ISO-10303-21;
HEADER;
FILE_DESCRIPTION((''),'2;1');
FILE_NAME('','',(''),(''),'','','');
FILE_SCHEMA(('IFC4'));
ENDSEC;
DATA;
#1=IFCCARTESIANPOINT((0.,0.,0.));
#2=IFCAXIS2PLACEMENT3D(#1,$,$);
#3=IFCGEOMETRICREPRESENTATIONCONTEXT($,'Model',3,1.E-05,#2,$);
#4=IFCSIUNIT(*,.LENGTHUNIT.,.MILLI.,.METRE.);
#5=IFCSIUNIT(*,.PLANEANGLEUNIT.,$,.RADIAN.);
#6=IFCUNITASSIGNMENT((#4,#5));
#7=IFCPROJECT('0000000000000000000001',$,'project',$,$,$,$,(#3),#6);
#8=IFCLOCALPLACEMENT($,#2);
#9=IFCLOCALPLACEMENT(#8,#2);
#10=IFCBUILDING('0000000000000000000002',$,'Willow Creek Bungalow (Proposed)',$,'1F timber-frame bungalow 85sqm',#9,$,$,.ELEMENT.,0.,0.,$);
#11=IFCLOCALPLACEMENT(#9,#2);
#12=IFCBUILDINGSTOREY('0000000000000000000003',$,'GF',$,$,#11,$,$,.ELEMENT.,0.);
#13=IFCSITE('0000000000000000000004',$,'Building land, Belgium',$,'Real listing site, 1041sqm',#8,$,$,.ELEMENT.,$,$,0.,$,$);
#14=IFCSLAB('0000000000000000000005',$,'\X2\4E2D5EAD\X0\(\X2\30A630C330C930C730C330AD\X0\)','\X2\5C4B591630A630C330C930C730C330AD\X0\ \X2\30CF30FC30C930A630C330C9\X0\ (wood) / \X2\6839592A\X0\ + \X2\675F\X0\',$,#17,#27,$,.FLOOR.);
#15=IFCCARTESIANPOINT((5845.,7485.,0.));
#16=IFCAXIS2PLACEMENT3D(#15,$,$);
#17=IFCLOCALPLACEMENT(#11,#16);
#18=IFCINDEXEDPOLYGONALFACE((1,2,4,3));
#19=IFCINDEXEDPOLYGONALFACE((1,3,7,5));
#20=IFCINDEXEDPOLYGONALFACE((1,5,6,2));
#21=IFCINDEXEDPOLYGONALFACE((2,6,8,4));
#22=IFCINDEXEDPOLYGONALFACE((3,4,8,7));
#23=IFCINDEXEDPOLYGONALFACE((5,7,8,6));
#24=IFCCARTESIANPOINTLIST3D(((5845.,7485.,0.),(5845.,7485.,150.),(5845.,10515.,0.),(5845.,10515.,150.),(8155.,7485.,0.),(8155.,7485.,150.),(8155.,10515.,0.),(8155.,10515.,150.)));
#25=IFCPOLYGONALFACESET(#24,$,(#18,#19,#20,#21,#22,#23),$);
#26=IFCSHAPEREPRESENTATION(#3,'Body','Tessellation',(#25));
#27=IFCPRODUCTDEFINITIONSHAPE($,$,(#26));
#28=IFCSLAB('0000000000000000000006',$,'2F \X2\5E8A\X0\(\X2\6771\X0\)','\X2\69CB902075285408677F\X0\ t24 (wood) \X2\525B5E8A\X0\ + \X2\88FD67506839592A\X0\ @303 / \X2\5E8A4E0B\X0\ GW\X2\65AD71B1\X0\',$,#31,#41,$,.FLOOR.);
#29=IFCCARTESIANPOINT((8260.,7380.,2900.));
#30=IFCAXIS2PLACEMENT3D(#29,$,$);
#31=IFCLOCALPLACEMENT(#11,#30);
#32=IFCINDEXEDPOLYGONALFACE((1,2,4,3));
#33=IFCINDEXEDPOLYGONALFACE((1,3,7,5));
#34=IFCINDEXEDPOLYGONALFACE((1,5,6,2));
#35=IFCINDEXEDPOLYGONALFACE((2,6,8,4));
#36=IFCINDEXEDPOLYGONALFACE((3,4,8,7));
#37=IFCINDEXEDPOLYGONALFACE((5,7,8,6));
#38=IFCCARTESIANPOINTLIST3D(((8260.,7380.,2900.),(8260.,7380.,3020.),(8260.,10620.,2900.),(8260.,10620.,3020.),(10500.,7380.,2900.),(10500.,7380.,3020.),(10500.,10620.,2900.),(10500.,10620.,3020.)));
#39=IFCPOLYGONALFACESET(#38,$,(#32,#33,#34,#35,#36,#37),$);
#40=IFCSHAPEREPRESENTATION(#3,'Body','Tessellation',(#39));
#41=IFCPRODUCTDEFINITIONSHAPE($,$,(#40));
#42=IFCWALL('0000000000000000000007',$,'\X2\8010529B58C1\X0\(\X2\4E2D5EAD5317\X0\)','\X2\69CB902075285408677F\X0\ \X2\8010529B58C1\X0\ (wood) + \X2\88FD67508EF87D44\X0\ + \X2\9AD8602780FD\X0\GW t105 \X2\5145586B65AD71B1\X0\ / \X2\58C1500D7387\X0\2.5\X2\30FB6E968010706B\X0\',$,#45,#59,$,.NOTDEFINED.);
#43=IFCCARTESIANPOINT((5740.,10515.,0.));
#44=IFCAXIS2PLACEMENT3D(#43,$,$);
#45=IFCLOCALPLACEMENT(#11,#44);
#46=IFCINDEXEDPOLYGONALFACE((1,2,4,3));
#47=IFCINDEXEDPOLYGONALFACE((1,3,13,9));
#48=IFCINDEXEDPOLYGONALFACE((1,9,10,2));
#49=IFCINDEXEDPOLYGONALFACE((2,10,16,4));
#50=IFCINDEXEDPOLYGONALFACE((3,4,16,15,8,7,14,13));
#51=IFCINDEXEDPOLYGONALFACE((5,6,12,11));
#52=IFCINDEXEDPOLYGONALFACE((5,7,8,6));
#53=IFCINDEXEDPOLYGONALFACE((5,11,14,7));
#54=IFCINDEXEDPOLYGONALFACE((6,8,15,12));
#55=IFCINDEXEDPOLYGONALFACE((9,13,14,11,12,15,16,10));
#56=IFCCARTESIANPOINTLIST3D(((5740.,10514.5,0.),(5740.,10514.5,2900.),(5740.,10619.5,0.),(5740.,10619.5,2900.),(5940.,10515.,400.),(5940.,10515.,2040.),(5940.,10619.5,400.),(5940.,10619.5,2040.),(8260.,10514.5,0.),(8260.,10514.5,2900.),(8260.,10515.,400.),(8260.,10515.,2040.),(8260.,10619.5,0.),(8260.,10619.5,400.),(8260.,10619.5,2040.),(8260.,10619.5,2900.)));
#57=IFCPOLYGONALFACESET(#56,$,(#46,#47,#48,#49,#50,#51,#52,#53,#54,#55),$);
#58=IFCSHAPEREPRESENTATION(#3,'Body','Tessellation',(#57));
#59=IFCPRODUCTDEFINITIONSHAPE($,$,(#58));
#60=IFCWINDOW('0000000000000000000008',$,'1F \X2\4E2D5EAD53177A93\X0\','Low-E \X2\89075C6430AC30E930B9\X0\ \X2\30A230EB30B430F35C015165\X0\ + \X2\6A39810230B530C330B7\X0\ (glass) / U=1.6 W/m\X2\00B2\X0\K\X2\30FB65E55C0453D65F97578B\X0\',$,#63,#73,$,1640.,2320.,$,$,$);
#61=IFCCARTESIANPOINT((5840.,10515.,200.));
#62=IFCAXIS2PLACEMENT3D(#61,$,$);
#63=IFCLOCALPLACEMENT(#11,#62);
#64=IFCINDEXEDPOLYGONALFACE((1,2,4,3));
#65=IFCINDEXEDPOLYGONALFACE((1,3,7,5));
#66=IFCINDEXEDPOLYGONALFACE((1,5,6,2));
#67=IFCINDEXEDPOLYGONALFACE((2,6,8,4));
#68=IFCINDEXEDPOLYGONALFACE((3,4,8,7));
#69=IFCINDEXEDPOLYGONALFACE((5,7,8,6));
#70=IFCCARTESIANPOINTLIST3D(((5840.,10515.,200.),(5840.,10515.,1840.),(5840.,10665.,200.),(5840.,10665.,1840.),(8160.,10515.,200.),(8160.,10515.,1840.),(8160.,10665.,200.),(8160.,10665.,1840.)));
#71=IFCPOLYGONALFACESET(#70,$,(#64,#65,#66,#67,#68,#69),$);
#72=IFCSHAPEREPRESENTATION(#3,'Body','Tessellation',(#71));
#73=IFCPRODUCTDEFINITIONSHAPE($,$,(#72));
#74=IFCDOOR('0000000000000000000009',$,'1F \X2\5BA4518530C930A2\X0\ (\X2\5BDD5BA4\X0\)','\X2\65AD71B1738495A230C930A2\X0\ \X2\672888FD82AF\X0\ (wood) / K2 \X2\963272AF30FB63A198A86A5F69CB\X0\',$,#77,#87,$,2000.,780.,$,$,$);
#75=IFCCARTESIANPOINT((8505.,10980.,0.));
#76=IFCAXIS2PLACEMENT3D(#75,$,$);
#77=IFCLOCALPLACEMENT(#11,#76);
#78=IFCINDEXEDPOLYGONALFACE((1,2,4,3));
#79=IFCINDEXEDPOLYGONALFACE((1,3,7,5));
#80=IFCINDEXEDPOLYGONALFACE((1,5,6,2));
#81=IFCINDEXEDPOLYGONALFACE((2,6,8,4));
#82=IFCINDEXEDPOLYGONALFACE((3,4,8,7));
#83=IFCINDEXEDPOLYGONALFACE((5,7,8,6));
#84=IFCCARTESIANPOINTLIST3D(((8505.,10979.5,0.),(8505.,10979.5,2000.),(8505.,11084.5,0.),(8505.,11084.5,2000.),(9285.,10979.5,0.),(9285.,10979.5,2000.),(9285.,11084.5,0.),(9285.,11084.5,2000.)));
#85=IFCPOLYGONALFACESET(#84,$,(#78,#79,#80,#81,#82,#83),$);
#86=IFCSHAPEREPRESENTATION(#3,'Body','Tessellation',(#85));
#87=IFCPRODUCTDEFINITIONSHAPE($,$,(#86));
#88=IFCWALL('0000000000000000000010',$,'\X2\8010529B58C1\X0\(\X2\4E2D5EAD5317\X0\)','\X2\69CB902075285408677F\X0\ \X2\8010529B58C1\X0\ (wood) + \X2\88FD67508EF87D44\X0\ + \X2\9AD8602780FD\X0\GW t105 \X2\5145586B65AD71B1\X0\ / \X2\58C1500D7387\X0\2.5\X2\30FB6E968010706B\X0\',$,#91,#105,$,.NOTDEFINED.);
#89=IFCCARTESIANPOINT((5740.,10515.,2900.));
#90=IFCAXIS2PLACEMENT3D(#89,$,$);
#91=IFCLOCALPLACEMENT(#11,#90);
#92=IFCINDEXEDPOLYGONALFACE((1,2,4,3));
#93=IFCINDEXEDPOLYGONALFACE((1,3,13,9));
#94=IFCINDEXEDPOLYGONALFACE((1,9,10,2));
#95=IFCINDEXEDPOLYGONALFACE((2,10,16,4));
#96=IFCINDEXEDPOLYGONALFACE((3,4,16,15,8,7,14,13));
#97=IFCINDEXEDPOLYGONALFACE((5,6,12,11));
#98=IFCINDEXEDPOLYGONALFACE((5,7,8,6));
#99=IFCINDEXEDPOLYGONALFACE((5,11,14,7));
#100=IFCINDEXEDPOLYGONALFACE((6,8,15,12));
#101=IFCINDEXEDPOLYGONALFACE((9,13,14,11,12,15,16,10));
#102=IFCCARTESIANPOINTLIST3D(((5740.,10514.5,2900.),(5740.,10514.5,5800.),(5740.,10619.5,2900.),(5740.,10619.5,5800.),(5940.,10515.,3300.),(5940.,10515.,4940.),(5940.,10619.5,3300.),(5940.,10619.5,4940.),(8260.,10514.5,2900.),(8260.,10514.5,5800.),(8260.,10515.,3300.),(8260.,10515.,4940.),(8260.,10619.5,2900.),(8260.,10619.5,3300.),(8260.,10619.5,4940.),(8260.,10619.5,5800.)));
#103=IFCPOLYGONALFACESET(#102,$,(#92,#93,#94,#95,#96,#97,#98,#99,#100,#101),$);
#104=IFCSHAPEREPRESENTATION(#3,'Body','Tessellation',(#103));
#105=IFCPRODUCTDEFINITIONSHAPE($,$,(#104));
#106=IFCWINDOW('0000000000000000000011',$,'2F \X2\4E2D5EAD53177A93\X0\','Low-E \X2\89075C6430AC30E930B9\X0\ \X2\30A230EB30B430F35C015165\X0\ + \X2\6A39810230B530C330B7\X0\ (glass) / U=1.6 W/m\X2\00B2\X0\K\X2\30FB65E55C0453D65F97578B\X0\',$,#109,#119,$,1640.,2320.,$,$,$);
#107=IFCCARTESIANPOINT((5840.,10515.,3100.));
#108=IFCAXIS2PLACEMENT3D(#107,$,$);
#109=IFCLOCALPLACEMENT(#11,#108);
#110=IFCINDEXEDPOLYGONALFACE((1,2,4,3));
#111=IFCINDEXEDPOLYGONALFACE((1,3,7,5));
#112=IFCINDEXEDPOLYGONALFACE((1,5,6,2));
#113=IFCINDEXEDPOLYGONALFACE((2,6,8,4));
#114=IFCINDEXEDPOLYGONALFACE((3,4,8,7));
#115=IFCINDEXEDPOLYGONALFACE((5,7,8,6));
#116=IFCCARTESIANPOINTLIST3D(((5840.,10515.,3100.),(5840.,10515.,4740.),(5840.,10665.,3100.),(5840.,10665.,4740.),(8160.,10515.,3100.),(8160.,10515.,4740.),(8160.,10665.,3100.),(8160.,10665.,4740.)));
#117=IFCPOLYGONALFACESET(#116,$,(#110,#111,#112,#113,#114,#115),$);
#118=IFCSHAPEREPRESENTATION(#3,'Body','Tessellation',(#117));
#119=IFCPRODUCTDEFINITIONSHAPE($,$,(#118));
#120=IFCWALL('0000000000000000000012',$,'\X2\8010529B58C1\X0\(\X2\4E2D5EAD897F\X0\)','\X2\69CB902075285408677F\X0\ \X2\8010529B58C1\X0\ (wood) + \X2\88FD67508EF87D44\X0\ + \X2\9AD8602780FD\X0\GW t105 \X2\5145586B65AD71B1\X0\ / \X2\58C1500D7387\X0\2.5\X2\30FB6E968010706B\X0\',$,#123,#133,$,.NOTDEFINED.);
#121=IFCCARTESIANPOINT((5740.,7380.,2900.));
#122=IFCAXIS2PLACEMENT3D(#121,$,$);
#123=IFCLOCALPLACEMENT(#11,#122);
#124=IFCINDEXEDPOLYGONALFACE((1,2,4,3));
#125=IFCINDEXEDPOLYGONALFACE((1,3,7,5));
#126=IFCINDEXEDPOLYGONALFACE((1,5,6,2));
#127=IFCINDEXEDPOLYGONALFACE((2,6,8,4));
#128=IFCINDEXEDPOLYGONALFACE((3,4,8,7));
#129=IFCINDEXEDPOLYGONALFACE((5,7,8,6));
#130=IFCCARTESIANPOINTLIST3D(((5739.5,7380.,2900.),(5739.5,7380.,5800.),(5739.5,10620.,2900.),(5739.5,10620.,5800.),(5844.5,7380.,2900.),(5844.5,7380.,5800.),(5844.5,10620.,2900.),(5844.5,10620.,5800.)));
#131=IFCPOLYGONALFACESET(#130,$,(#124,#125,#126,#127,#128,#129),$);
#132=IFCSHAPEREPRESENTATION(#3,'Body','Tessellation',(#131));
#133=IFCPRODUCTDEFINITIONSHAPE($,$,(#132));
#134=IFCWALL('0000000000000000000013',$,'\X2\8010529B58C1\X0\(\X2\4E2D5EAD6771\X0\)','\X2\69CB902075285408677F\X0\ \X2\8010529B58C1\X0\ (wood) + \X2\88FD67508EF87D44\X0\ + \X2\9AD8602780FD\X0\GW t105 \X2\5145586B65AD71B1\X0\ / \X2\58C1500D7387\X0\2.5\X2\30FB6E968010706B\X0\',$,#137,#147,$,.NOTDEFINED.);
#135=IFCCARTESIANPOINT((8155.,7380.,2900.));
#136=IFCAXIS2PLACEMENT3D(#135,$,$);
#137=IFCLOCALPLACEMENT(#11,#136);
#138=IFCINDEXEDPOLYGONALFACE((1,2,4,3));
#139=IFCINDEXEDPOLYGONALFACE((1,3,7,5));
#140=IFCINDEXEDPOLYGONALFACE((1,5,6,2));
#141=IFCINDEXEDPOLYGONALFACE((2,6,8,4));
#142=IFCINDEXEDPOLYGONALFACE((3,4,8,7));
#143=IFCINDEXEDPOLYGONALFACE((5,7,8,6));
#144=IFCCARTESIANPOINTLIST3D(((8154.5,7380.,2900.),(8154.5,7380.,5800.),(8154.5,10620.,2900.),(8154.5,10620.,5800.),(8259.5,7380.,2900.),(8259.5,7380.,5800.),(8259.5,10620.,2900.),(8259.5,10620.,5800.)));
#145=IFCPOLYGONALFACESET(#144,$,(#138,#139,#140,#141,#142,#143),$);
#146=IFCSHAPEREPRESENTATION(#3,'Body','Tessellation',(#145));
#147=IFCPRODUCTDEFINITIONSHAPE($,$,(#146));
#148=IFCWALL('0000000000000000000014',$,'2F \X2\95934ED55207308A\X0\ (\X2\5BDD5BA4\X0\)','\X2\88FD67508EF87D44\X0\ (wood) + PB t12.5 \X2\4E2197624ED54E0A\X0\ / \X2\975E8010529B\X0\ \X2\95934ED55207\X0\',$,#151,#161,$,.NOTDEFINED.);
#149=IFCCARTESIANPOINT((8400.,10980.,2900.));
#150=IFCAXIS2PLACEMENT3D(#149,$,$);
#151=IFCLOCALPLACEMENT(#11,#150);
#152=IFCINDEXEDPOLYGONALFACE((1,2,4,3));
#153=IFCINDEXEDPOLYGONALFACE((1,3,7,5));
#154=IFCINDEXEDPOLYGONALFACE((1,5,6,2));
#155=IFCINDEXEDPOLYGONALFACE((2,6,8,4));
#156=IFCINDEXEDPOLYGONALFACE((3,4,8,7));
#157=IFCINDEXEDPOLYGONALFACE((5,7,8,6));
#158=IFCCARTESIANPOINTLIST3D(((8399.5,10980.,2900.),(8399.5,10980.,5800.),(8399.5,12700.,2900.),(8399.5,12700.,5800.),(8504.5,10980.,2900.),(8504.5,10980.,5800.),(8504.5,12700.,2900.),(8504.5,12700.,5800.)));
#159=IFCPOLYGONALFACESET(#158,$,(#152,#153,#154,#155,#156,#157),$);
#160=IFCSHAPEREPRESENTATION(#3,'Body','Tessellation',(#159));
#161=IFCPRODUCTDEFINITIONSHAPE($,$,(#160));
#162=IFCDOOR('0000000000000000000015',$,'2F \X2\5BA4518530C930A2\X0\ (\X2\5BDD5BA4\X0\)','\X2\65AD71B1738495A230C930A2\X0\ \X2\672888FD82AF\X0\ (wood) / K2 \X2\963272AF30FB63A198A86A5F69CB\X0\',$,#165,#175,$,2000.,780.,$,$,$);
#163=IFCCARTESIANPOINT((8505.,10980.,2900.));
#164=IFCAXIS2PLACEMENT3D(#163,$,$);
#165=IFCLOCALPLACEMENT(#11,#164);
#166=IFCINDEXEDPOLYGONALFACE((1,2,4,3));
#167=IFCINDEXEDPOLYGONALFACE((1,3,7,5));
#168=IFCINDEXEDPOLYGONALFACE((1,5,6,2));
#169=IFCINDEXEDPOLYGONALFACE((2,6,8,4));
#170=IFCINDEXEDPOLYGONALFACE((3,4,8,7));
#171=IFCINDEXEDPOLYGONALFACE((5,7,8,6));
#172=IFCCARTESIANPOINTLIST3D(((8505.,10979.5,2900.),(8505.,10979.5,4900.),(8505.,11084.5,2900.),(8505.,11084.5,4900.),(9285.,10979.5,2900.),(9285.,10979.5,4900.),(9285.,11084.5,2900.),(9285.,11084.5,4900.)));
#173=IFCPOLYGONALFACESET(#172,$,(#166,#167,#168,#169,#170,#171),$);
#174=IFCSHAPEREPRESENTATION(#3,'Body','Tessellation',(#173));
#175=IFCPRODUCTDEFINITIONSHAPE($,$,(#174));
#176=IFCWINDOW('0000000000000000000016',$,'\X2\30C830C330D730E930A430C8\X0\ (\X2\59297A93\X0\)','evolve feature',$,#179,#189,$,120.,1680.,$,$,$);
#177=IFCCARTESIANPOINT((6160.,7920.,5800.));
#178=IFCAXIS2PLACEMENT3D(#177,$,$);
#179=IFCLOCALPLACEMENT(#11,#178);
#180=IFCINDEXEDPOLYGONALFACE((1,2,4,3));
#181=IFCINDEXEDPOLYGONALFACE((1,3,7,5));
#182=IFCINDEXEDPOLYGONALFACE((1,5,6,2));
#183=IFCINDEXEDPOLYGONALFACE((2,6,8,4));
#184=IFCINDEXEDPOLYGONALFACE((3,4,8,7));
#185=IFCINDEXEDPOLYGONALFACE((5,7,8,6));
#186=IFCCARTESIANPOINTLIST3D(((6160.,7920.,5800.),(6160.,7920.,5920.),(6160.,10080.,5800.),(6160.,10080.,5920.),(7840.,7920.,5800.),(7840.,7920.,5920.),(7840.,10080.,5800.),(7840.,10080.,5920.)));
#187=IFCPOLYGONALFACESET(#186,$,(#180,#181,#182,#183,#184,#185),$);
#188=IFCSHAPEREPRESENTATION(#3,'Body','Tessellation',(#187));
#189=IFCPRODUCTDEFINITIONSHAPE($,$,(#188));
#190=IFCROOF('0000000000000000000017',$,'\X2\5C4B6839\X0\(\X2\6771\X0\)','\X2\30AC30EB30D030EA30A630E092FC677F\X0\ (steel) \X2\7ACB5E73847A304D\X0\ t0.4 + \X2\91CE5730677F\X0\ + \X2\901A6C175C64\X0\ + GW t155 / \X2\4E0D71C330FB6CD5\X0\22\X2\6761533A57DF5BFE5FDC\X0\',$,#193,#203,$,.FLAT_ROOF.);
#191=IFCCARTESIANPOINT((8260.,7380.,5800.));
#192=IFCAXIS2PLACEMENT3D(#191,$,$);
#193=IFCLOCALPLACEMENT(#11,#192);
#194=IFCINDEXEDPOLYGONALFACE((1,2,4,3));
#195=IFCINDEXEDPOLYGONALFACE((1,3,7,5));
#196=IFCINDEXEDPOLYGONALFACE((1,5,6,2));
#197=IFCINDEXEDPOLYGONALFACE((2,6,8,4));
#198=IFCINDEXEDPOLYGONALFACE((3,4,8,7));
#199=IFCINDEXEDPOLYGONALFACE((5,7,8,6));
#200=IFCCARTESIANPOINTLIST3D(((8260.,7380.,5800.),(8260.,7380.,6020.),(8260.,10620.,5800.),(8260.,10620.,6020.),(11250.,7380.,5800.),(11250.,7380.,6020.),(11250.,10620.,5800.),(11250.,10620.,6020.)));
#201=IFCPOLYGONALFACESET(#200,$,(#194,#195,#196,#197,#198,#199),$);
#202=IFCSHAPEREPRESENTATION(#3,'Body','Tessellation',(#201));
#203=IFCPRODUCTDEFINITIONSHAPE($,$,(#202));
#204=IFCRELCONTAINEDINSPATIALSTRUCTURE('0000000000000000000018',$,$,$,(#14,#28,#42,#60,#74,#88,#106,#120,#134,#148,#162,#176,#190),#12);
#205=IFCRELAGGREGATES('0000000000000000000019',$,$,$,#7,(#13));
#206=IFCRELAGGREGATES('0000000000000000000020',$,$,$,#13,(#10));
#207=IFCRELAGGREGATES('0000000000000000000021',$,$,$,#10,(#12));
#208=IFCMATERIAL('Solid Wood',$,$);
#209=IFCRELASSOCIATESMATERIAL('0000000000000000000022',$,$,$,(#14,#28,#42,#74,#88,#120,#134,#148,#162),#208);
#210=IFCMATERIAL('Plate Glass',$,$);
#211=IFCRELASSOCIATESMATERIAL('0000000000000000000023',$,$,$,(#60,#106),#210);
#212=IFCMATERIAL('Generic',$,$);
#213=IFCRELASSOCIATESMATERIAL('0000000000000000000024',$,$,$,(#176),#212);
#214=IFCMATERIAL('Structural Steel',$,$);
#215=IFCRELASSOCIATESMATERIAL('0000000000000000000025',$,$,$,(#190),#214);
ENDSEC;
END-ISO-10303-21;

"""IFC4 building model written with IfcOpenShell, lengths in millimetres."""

from ifc_helpers import new_model, si_unit, frame, frame_2d, origin, place, context, project, spatial, rectangle, extrude, material, element, fill, save


model = new_model("IFC4")

# Units and contexts
model_context = context("Model", 3, precision=1e-05, world=origin())
ifc_project = project(units=[si_unit("LENGTHUNIT", "METRE", prefix="MILLI"), si_unit("PLANEANGLEUNIT", "RADIAN")], contexts=[model_context])

# Site, building, storey
site_placement = place(None, origin())
site = spatial("IfcSite", under=ifc_project, at=site_placement, Name="Building land, Belgium", ObjectType="Real listing site, 1041sqm", CompositionType="ELEMENT", RefElevation=0.0)
building_placement = place(site_placement, origin())
building = spatial("IfcBuilding", under=site, at=building_placement, Name="Willow Creek Bungalow (Proposed)", ObjectType="1F timber-frame bungalow 85sqm", CompositionType="ELEMENT", ElevationOfRefHeight=0.0, ElevationOfTerrain=0.0)
storey_placement = place(building_placement, origin())
storey = spatial("IfcBuildingStorey", under=building, at=storey_placement, Name="GF", CompositionType="ELEMENT", Elevation=0.0)

# Slabs
ifc_material_1 = material(Name="Solid Wood")
slab_1_placement = place(storey_placement, frame((5845.0, 7485.0, 0.0)))
element("IfcSlab", 1, at=slab_1_placement, inside=storey, material=ifc_material_1, Name="中庭(ウッドデッキ)", Description="屋外ウッドデッキ ハードウッド (wood) / 根太 + 束", PredefinedType="FLOOR", context=model_context, shape_type="SweptSolid", body=[
    extrude(rectangle(XDim=2310.0, YDim=3030.0, at=frame_2d((1155.0, 1515.0))), frame((5845.0, 7485.0, 0.0)), (0.0, 0.0, 1.0), 150.0),
])
slab_2_placement = place(storey_placement, frame((8260.0, 7380.0, 2900.0)))
element("IfcSlab", 2, at=slab_2_placement, inside=storey, material=ifc_material_1, Name="2F 床(東)", Description="構造用合板 t24 (wood) 剛床 + 製材根太 @303 / 床下 GW断熱", PredefinedType="FLOOR", context=model_context, shape_type="SweptSolid", body=[
    extrude(rectangle(XDim=2240.0, YDim=3240.0, at=frame_2d((1120.0, 1620.0))), frame((8260.0, 7380.0, 2900.0)), (0.0, 0.0, 1.0), 120.0),
])

# Wall, opening, window
wall_1_placement = place(storey_placement, frame((5740.0, 10515.0, 0.0)))
wall_1 = element("IfcWall", 3, at=wall_1_placement, inside=storey, material=ifc_material_1, Name="耐力壁(中庭北)", Description="構造用合板 耐力壁 (wood) + 製材軸組 + 高性能GW t105 充填断熱 / 壁倍率2.5・準耐火", PredefinedType="NOTDEFINED", context=model_context, shape_type="SweptSolid", body=[
    extrude(rectangle(XDim=2520.0, YDim=105.0, at=frame_2d((1260.0, 52.0))), frame((5740.0, 10515.0, 0.0)), (0.0, 0.0, 1.0), 2900.0),
])
opening_1_placement = place(storey_placement, frame((5840.0, 10515.0, 200.0)))
opening_1 = element("IfcOpeningElement", 4, at=opening_1_placement, cuts=wall_1, PredefinedType="NOTDEFINED", context=model_context, shape_type="SweptSolid", body=[
    extrude(rectangle(XDim=2320.0, YDim=150.0, at=frame_2d((1160.0, 75.0))), frame((5840.0, 10515.0, 200.0)), (0.0, 0.0, 1.0), 1640.0),
])
ifc_material_2 = material(Name="Plate Glass")
window_1_placement = place(storey_placement, frame((5840.0, 10515.0, 200.0)))
window_1 = element("IfcWindow", 5, at=window_1_placement, inside=storey, material=ifc_material_2, Name="1F 中庭北窓", Description="Low-E 複層ガラス アルゴン封入 + 樹脂サッシ (glass) / U=1.6 W/m²K・日射取得型", OverallHeight=1640.0, OverallWidth=2320.0, context=model_context, shape_type="SweptSolid", body=[
    extrude(rectangle(XDim=2320.0, YDim=150.0, at=frame_2d((1160.0, 75.0))), frame((5840.0, 10515.0, 200.0)), (0.0, 0.0, 1.0), 1640.0),
])
fill(opening_1, window_1)

# Door
door_1_placement = place(storey_placement, frame((8505.0, 10980.0, 0.0)))
element("IfcDoor", 6, at=door_1_placement, inside=storey, material=ifc_material_1, Name="1F 室内ドア (寝室)", Description="断熱玄関ドア 木製芯 (wood) / K2 防犯・採風機構", OverallHeight=2000.0, OverallWidth=780.0, context=model_context, shape_type="SweptSolid", body=[
    extrude(rectangle(XDim=780.0, YDim=105.0, at=frame_2d((390.0, 52.0))), frame((8505.0, 10980.0, 0.0)), (0.0, 0.0, 1.0), 2000.0),
])

# Wall, opening, window
wall_2_placement = place(storey_placement, frame((5740.0, 10515.0, 2900.0)))
wall_2 = element("IfcWall", 7, at=wall_2_placement, inside=storey, material=ifc_material_1, Name="耐力壁(中庭北)", Description="構造用合板 耐力壁 (wood) + 製材軸組 + 高性能GW t105 充填断熱 / 壁倍率2.5・準耐火", PredefinedType="NOTDEFINED", context=model_context, shape_type="SweptSolid", body=[
    extrude(rectangle(XDim=2520.0, YDim=105.0, at=frame_2d((1260.0, 52.0))), frame((5740.0, 10515.0, 2900.0)), (0.0, 0.0, 1.0), 2900.0),
])
opening_2_placement = place(storey_placement, frame((5840.0, 10515.0, 3100.0)))
opening_2 = element("IfcOpeningElement", 8, at=opening_2_placement, cuts=wall_2, PredefinedType="NOTDEFINED", context=model_context, shape_type="SweptSolid", body=[
    extrude(rectangle(XDim=2320.0, YDim=150.0, at=frame_2d((1160.0, 75.0))), frame((5840.0, 10515.0, 3100.0)), (0.0, 0.0, 1.0), 1640.0),
])
window_2_placement = place(storey_placement, frame((5840.0, 10515.0, 3100.0)))
window_2 = element("IfcWindow", 9, at=window_2_placement, inside=storey, material=ifc_material_2, Name="2F 中庭北窓", Description="Low-E 複層ガラス アルゴン封入 + 樹脂サッシ (glass) / U=1.6 W/m²K・日射取得型", OverallHeight=1640.0, OverallWidth=2320.0, context=model_context, shape_type="SweptSolid", body=[
    extrude(rectangle(XDim=2320.0, YDim=150.0, at=frame_2d((1160.0, 75.0))), frame((5840.0, 10515.0, 3100.0)), (0.0, 0.0, 1.0), 1640.0),
])
fill(opening_2, window_2)

# Walls
wall_3_placement = place(storey_placement, frame((5740.0, 7380.0, 2900.0)))
element("IfcWall", 10, at=wall_3_placement, inside=storey, material=ifc_material_1, Name="耐力壁(中庭西)", Description="構造用合板 耐力壁 (wood) + 製材軸組 + 高性能GW t105 充填断熱 / 壁倍率2.5・準耐火", PredefinedType="NOTDEFINED", context=model_context, shape_type="SweptSolid", body=[
    extrude(rectangle(XDim=105.0, YDim=3240.0, at=frame_2d((52.0, 1620.0))), frame((5740.0, 7380.0, 2900.0)), (0.0, 0.0, 1.0), 2900.0),
])
wall_4_placement = place(storey_placement, frame((8155.0, 7380.0, 2900.0)))
element("IfcWall", 11, at=wall_4_placement, inside=storey, material=ifc_material_1, Name="耐力壁(中庭東)", Description="構造用合板 耐力壁 (wood) + 製材軸組 + 高性能GW t105 充填断熱 / 壁倍率2.5・準耐火", PredefinedType="NOTDEFINED", context=model_context, shape_type="SweptSolid", body=[
    extrude(rectangle(XDim=105.0, YDim=3240.0, at=frame_2d((52.0, 1620.0))), frame((8155.0, 7380.0, 2900.0)), (0.0, 0.0, 1.0), 2900.0),
])
wall_5_placement = place(storey_placement, frame((8400.0, 10980.0, 2900.0)))
element("IfcWall", 12, at=wall_5_placement, inside=storey, material=ifc_material_1, Name="2F 間仕切り (寝室)", Description="製材軸組 (wood) + PB t12.5 両面仕上 / 非耐力 間仕切", PredefinedType="NOTDEFINED", context=model_context, shape_type="SweptSolid", body=[
    extrude(rectangle(XDim=105.0, YDim=1720.0, at=frame_2d((52.0, 860.0))), frame((8400.0, 10980.0, 2900.0)), (0.0, 0.0, 1.0), 2900.0),
])

# Door
door_2_placement = place(storey_placement, frame((8505.0, 10980.0, 2900.0)))
element("IfcDoor", 13, at=door_2_placement, inside=storey, material=ifc_material_1, Name="2F 室内ドア (寝室)", Description="断熱玄関ドア 木製芯 (wood) / K2 防犯・採風機構", OverallHeight=2000.0, OverallWidth=780.0, context=model_context, shape_type="SweptSolid", body=[
    extrude(rectangle(XDim=780.0, YDim=105.0, at=frame_2d((390.0, 52.0))), frame((8505.0, 10980.0, 2900.0)), (0.0, 0.0, 1.0), 2000.0),
])

# Window
ifc_material_3 = material(Name="Generic")
window_3_placement = place(storey_placement, frame((6160.0, 7920.0, 5800.0)))
element("IfcWindow", 14, at=window_3_placement, inside=storey, material=ifc_material_3, Name="トップライト (天窓)", Description="evolve feature", OverallHeight=120.0, OverallWidth=1680.0, context=model_context, shape_type="SweptSolid", body=[
    extrude(rectangle(XDim=1680.0, YDim=2160.0, at=frame_2d((840.0, 1080.0))), frame((6160.0, 7920.0, 5800.0)), (0.0, 0.0, 1.0), 120.0),
])

# Roof
ifc_material_4 = material(Name="Structural Steel")
roof_placement = place(storey_placement, frame((8260.0, 7380.0, 5800.0)))
element("IfcRoof", 15, at=roof_placement, inside=storey, material=ifc_material_4, Name="屋根(東)", Description="ガルバリウム鋼板 (steel) 立平葺き t0.4 + 野地板 + 通気層 + GW t155 / 不燃・法22条区域対応", PredefinedType="FLAT_ROOF", context=model_context, shape_type="SweptSolid", body=[
    extrude(rectangle(XDim=2990.0, YDim=3240.0, at=frame_2d((1495.0, 1620.0))), frame((8260.0, 7380.0, 5800.0)), (0.0, 0.0, 1.0), 220.0),
])

save(model, "model.ifc")
